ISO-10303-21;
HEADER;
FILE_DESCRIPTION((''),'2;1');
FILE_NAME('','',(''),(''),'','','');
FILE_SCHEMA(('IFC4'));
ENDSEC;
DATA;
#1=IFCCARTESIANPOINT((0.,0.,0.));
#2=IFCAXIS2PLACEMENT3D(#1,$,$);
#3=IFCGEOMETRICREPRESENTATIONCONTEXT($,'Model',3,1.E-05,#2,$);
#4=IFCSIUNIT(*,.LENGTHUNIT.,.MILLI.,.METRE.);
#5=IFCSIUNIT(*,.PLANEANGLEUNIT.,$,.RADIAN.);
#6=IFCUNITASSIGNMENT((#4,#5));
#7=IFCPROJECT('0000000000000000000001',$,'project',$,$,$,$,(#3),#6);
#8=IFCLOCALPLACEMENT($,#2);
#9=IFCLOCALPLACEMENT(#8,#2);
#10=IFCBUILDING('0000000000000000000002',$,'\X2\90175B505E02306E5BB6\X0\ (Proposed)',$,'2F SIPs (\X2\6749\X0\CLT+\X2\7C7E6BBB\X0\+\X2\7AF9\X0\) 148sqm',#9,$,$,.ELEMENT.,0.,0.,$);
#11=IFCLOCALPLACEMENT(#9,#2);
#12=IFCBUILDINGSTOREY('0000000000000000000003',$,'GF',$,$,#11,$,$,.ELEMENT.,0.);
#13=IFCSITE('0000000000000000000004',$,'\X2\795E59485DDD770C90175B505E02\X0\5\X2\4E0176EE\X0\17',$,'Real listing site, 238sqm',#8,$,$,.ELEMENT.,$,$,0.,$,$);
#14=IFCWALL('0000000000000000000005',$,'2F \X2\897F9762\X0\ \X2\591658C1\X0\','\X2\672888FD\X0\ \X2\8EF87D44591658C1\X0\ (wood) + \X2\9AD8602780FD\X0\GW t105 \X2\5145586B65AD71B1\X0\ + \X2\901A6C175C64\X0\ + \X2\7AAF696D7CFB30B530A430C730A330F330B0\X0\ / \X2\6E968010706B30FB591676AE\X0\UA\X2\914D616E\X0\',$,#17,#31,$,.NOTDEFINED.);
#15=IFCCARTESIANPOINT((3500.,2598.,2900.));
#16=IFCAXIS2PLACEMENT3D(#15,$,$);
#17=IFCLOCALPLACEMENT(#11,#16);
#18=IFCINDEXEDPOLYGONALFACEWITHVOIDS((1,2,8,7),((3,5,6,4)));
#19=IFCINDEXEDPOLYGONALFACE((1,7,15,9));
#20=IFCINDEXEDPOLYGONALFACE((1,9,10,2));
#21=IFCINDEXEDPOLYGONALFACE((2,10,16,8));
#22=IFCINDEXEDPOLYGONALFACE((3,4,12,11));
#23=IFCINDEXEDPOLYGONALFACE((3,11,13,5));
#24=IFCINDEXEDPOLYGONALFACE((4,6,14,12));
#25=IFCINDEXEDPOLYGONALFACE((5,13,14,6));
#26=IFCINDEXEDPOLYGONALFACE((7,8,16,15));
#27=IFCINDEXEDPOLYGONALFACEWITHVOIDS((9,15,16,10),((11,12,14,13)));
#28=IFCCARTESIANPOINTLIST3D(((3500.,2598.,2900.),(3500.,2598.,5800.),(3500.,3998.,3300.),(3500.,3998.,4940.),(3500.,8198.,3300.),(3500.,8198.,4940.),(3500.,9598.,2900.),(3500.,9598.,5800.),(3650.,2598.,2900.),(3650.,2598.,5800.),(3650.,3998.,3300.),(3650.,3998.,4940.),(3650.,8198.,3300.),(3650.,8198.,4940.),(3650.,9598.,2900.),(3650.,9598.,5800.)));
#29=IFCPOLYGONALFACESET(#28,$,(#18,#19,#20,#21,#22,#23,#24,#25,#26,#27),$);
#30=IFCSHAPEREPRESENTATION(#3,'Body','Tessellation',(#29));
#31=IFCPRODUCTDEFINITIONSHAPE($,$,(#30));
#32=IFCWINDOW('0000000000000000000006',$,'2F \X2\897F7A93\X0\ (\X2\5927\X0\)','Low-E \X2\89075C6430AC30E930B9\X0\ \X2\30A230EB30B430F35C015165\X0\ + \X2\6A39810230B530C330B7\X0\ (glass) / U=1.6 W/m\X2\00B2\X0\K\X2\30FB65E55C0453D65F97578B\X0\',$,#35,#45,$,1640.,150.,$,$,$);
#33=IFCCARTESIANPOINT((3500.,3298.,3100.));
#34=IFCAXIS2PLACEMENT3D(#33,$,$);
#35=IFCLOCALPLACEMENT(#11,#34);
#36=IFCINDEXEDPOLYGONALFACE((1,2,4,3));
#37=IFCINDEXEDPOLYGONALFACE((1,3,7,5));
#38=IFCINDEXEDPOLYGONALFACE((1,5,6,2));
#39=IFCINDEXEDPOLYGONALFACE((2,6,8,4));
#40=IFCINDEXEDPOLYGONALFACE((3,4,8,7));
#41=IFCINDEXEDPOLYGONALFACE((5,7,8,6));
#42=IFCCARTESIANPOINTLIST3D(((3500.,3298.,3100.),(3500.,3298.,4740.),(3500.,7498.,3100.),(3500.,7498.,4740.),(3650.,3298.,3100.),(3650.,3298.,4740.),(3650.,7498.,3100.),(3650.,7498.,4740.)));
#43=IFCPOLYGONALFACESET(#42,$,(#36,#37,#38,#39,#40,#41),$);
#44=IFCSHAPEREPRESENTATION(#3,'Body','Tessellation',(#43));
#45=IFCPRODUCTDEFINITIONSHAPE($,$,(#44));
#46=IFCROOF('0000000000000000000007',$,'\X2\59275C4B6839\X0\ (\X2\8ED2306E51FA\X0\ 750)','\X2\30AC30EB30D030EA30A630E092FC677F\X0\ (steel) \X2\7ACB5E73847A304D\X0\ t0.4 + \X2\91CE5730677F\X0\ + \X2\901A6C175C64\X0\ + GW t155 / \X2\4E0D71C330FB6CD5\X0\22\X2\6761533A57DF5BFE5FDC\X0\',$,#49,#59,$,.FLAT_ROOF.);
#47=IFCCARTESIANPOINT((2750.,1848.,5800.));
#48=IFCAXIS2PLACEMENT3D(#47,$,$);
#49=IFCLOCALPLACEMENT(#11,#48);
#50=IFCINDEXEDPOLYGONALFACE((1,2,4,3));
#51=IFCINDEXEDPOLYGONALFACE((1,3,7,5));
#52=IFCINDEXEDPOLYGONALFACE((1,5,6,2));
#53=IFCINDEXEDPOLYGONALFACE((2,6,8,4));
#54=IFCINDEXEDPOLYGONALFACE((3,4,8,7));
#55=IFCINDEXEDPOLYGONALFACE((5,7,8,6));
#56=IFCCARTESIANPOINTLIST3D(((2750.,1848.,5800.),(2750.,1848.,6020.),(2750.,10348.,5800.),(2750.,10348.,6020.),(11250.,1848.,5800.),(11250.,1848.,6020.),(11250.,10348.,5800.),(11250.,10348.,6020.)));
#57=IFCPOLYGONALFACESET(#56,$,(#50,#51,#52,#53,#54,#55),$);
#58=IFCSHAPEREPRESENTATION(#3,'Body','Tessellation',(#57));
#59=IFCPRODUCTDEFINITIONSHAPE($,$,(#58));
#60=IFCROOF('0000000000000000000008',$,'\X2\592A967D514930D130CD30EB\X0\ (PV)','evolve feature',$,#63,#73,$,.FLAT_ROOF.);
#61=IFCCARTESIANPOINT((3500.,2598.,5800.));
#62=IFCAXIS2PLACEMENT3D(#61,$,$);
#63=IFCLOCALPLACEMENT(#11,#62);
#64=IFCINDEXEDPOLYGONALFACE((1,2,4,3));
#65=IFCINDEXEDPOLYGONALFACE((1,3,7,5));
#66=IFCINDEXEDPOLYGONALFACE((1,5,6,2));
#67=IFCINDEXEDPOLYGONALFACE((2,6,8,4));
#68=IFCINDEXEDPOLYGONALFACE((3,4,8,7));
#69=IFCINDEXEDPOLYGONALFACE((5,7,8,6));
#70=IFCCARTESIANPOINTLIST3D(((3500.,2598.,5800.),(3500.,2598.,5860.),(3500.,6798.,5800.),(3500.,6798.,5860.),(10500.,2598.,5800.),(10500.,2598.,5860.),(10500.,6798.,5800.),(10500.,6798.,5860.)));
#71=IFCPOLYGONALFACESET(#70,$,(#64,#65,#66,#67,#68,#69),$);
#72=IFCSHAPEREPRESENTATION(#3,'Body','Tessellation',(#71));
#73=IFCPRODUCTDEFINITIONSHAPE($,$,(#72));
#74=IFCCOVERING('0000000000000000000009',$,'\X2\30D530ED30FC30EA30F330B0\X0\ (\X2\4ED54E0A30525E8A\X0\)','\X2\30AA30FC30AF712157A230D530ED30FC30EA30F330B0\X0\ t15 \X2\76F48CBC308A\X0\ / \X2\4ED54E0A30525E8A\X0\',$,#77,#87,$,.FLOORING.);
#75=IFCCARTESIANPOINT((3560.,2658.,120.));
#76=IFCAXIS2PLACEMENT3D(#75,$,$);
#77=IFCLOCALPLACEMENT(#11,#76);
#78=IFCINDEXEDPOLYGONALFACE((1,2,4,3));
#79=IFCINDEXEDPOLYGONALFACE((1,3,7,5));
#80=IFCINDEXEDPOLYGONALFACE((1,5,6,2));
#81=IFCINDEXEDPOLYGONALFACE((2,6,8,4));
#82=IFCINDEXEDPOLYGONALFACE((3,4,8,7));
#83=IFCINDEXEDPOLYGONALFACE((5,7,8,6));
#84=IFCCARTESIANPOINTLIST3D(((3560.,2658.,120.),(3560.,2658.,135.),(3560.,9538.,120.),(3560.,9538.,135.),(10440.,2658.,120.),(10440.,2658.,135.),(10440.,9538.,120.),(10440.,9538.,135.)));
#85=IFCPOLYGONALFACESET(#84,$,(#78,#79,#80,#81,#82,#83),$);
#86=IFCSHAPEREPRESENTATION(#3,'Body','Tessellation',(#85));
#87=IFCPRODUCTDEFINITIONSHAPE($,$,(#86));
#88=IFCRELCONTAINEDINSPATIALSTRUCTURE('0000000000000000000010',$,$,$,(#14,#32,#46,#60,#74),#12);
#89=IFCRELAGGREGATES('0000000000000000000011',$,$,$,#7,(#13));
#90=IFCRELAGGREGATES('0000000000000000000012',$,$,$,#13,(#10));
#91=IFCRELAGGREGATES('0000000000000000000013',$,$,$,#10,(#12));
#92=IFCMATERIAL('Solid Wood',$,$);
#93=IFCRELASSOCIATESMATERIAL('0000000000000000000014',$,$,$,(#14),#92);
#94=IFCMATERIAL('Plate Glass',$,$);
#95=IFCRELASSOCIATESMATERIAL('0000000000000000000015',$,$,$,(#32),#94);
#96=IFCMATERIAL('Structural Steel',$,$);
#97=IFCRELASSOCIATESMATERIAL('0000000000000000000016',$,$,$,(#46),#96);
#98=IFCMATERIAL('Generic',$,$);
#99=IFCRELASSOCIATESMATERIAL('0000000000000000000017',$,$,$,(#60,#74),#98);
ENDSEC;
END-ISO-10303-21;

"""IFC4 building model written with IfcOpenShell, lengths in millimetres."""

from ifc_helpers import new_model, si_unit, frame, frame_2d, origin, place, context, project, spatial, rectangle, extrude, material, element, fill, save


model = new_model("IFC4")

# Units and contexts
model_context = context("Model", 3, precision=1e-05, world=origin())
ifc_project = project(units=[si_unit("LENGTHUNIT", "METRE", prefix="MILLI"), si_unit("PLANEANGLEUNIT", "RADIAN")], contexts=[model_context])

# Site, building, storey
site_placement = place(None, origin())
site = spatial("IfcSite", under=ifc_project, at=site_placement, Name="神奈川県逗子市5丁目17", ObjectType="Real listing site, 238sqm", CompositionType="ELEMENT", RefElevation=0.0)
building_placement = place(site_placement, origin())
building = spatial("IfcBuilding", under=site, at=building_placement, Name="逗子市の家 (Proposed)", ObjectType="2F SIPs (杉CLT+籾殻+竹) 148sqm", CompositionType="ELEMENT", ElevationOfRefHeight=0.0, ElevationOfTerrain=0.0)
storey_placement = place(building_placement, origin())
storey = spatial("IfcBuildingStorey", under=building, at=storey_placement, Name="GF", CompositionType="ELEMENT", Elevation=0.0)

# Shared definitions
ifc_material_1 = material(Name="Solid Wood")
ifc_material_2 = material(Name="Generic")

# Shared definitions
ifc_material_3 = material(Name="Plate Glass")

# Wall, opening, window
wall_1_placement = place(storey_placement, frame((3500.0, 2598.0, 2900.0)))
wall_1 = element("IfcWall", 1, at=wall_1_placement, inside=storey, material=ifc_material_1, Name="2F 西面 外壁", Description="木製 軸組外壁 (wood) + 高性能GW t105 充填断熱 + 通気層 + 窯業系サイディング / 準耐火・外皮UA配慮", PredefinedType="NOTDEFINED", context=model_context, shape_type="SweptSolid", body=[
    extrude(rectangle(XDim=150.0, YDim=7000.0, at=frame_2d((75.0, 3500.0))), frame((3500.0, 2598.0, 2900.0)), (0.0, 0.0, 1.0), 2900.0),
])
opening_1_placement = place(storey_placement, frame((3500.0, 3298.0, 3100.0)))
opening_1 = element("IfcOpeningElement", 2, at=opening_1_placement, cuts=wall_1, PredefinedType="NOTDEFINED", context=model_context, shape_type="SweptSolid", body=[
    extrude(rectangle(XDim=150.0, YDim=4200.0, at=frame_2d((75.0, 2100.0))), frame((3500.0, 3298.0, 3100.0)), (0.0, 0.0, 1.0), 1640.0),
])
window_1_placement = place(storey_placement, frame((3500.0, 3298.0, 3100.0)))
window_1 = element("IfcWindow", 3, at=window_1_placement, inside=storey, material=ifc_material_3, Name="2F 西窓 (大)", Description="Low-E 複層ガラス アルゴン封入 + 樹脂サッシ (glass) / U=1.6 W/m²K・日射取得型", OverallHeight=1640.0, OverallWidth=150.0, context=model_context, shape_type="SweptSolid", body=[
    extrude(rectangle(XDim=150.0, YDim=4200.0, at=frame_2d((75.0, 2100.0))), frame((3500.0, 3298.0, 3100.0)), (0.0, 0.0, 1.0), 1640.0),
])
fill(opening_1, window_1)

# Roofs
ifc_material_4 = material(Name="Structural Steel")
roof_1_placement = place(storey_placement, frame((2750.0, 1848.0, 5800.0)))
element("IfcRoof", 4, at=roof_1_placement, inside=storey, material=ifc_material_4, Name="大屋根 (軒の出 750)", Description="ガルバリウム鋼板 (steel) 立平葺き t0.4 + 野地板 + 通気層 + GW t155 / 不燃・法22条区域対応", PredefinedType="FLAT_ROOF", context=model_context, shape_type="SweptSolid", body=[
    extrude(rectangle(XDim=8500.0, YDim=8500.0, at=frame_2d((4250.0, 4250.0))), frame((2750.0, 1848.0, 5800.0)), (0.0, 0.0, 1.0), 220.0),
])
roof_2_placement = place(storey_placement, frame((3500.0, 2598.0, 5800.0)))
element("IfcRoof", 5, at=roof_2_placement, inside=storey, material=ifc_material_2, Name="太陽光パネル (PV)", Description="evolve feature", PredefinedType="FLAT_ROOF", context=model_context, shape_type="SweptSolid", body=[
    extrude(rectangle(XDim=7000.0, YDim=4200.0, at=frame_2d((3500.0, 2100.0))), frame((3500.0, 2598.0, 5800.0)), (0.0, 0.0, 1.0), 60.0),
])

# Covering
covering_placement = place(storey_placement, frame((3560.0, 2658.0, 120.0)))
element("IfcCovering", 6, at=covering_placement, inside=storey, material=ifc_material_2, Name="フローリング (仕上げ床)", Description="オーク無垢フローリング t15 直貼り / 仕上げ床", PredefinedType="FLOORING", context=model_context, shape_type="SweptSolid", body=[
    extrude(rectangle(XDim=6880.0, YDim=6880.0, at=frame_2d((3440.0, 3440.0))), frame((3560.0, 2658.0, 120.0)), (0.0, 0.0, 1.0), 15.0),
])

save(model, "model.ifc")
